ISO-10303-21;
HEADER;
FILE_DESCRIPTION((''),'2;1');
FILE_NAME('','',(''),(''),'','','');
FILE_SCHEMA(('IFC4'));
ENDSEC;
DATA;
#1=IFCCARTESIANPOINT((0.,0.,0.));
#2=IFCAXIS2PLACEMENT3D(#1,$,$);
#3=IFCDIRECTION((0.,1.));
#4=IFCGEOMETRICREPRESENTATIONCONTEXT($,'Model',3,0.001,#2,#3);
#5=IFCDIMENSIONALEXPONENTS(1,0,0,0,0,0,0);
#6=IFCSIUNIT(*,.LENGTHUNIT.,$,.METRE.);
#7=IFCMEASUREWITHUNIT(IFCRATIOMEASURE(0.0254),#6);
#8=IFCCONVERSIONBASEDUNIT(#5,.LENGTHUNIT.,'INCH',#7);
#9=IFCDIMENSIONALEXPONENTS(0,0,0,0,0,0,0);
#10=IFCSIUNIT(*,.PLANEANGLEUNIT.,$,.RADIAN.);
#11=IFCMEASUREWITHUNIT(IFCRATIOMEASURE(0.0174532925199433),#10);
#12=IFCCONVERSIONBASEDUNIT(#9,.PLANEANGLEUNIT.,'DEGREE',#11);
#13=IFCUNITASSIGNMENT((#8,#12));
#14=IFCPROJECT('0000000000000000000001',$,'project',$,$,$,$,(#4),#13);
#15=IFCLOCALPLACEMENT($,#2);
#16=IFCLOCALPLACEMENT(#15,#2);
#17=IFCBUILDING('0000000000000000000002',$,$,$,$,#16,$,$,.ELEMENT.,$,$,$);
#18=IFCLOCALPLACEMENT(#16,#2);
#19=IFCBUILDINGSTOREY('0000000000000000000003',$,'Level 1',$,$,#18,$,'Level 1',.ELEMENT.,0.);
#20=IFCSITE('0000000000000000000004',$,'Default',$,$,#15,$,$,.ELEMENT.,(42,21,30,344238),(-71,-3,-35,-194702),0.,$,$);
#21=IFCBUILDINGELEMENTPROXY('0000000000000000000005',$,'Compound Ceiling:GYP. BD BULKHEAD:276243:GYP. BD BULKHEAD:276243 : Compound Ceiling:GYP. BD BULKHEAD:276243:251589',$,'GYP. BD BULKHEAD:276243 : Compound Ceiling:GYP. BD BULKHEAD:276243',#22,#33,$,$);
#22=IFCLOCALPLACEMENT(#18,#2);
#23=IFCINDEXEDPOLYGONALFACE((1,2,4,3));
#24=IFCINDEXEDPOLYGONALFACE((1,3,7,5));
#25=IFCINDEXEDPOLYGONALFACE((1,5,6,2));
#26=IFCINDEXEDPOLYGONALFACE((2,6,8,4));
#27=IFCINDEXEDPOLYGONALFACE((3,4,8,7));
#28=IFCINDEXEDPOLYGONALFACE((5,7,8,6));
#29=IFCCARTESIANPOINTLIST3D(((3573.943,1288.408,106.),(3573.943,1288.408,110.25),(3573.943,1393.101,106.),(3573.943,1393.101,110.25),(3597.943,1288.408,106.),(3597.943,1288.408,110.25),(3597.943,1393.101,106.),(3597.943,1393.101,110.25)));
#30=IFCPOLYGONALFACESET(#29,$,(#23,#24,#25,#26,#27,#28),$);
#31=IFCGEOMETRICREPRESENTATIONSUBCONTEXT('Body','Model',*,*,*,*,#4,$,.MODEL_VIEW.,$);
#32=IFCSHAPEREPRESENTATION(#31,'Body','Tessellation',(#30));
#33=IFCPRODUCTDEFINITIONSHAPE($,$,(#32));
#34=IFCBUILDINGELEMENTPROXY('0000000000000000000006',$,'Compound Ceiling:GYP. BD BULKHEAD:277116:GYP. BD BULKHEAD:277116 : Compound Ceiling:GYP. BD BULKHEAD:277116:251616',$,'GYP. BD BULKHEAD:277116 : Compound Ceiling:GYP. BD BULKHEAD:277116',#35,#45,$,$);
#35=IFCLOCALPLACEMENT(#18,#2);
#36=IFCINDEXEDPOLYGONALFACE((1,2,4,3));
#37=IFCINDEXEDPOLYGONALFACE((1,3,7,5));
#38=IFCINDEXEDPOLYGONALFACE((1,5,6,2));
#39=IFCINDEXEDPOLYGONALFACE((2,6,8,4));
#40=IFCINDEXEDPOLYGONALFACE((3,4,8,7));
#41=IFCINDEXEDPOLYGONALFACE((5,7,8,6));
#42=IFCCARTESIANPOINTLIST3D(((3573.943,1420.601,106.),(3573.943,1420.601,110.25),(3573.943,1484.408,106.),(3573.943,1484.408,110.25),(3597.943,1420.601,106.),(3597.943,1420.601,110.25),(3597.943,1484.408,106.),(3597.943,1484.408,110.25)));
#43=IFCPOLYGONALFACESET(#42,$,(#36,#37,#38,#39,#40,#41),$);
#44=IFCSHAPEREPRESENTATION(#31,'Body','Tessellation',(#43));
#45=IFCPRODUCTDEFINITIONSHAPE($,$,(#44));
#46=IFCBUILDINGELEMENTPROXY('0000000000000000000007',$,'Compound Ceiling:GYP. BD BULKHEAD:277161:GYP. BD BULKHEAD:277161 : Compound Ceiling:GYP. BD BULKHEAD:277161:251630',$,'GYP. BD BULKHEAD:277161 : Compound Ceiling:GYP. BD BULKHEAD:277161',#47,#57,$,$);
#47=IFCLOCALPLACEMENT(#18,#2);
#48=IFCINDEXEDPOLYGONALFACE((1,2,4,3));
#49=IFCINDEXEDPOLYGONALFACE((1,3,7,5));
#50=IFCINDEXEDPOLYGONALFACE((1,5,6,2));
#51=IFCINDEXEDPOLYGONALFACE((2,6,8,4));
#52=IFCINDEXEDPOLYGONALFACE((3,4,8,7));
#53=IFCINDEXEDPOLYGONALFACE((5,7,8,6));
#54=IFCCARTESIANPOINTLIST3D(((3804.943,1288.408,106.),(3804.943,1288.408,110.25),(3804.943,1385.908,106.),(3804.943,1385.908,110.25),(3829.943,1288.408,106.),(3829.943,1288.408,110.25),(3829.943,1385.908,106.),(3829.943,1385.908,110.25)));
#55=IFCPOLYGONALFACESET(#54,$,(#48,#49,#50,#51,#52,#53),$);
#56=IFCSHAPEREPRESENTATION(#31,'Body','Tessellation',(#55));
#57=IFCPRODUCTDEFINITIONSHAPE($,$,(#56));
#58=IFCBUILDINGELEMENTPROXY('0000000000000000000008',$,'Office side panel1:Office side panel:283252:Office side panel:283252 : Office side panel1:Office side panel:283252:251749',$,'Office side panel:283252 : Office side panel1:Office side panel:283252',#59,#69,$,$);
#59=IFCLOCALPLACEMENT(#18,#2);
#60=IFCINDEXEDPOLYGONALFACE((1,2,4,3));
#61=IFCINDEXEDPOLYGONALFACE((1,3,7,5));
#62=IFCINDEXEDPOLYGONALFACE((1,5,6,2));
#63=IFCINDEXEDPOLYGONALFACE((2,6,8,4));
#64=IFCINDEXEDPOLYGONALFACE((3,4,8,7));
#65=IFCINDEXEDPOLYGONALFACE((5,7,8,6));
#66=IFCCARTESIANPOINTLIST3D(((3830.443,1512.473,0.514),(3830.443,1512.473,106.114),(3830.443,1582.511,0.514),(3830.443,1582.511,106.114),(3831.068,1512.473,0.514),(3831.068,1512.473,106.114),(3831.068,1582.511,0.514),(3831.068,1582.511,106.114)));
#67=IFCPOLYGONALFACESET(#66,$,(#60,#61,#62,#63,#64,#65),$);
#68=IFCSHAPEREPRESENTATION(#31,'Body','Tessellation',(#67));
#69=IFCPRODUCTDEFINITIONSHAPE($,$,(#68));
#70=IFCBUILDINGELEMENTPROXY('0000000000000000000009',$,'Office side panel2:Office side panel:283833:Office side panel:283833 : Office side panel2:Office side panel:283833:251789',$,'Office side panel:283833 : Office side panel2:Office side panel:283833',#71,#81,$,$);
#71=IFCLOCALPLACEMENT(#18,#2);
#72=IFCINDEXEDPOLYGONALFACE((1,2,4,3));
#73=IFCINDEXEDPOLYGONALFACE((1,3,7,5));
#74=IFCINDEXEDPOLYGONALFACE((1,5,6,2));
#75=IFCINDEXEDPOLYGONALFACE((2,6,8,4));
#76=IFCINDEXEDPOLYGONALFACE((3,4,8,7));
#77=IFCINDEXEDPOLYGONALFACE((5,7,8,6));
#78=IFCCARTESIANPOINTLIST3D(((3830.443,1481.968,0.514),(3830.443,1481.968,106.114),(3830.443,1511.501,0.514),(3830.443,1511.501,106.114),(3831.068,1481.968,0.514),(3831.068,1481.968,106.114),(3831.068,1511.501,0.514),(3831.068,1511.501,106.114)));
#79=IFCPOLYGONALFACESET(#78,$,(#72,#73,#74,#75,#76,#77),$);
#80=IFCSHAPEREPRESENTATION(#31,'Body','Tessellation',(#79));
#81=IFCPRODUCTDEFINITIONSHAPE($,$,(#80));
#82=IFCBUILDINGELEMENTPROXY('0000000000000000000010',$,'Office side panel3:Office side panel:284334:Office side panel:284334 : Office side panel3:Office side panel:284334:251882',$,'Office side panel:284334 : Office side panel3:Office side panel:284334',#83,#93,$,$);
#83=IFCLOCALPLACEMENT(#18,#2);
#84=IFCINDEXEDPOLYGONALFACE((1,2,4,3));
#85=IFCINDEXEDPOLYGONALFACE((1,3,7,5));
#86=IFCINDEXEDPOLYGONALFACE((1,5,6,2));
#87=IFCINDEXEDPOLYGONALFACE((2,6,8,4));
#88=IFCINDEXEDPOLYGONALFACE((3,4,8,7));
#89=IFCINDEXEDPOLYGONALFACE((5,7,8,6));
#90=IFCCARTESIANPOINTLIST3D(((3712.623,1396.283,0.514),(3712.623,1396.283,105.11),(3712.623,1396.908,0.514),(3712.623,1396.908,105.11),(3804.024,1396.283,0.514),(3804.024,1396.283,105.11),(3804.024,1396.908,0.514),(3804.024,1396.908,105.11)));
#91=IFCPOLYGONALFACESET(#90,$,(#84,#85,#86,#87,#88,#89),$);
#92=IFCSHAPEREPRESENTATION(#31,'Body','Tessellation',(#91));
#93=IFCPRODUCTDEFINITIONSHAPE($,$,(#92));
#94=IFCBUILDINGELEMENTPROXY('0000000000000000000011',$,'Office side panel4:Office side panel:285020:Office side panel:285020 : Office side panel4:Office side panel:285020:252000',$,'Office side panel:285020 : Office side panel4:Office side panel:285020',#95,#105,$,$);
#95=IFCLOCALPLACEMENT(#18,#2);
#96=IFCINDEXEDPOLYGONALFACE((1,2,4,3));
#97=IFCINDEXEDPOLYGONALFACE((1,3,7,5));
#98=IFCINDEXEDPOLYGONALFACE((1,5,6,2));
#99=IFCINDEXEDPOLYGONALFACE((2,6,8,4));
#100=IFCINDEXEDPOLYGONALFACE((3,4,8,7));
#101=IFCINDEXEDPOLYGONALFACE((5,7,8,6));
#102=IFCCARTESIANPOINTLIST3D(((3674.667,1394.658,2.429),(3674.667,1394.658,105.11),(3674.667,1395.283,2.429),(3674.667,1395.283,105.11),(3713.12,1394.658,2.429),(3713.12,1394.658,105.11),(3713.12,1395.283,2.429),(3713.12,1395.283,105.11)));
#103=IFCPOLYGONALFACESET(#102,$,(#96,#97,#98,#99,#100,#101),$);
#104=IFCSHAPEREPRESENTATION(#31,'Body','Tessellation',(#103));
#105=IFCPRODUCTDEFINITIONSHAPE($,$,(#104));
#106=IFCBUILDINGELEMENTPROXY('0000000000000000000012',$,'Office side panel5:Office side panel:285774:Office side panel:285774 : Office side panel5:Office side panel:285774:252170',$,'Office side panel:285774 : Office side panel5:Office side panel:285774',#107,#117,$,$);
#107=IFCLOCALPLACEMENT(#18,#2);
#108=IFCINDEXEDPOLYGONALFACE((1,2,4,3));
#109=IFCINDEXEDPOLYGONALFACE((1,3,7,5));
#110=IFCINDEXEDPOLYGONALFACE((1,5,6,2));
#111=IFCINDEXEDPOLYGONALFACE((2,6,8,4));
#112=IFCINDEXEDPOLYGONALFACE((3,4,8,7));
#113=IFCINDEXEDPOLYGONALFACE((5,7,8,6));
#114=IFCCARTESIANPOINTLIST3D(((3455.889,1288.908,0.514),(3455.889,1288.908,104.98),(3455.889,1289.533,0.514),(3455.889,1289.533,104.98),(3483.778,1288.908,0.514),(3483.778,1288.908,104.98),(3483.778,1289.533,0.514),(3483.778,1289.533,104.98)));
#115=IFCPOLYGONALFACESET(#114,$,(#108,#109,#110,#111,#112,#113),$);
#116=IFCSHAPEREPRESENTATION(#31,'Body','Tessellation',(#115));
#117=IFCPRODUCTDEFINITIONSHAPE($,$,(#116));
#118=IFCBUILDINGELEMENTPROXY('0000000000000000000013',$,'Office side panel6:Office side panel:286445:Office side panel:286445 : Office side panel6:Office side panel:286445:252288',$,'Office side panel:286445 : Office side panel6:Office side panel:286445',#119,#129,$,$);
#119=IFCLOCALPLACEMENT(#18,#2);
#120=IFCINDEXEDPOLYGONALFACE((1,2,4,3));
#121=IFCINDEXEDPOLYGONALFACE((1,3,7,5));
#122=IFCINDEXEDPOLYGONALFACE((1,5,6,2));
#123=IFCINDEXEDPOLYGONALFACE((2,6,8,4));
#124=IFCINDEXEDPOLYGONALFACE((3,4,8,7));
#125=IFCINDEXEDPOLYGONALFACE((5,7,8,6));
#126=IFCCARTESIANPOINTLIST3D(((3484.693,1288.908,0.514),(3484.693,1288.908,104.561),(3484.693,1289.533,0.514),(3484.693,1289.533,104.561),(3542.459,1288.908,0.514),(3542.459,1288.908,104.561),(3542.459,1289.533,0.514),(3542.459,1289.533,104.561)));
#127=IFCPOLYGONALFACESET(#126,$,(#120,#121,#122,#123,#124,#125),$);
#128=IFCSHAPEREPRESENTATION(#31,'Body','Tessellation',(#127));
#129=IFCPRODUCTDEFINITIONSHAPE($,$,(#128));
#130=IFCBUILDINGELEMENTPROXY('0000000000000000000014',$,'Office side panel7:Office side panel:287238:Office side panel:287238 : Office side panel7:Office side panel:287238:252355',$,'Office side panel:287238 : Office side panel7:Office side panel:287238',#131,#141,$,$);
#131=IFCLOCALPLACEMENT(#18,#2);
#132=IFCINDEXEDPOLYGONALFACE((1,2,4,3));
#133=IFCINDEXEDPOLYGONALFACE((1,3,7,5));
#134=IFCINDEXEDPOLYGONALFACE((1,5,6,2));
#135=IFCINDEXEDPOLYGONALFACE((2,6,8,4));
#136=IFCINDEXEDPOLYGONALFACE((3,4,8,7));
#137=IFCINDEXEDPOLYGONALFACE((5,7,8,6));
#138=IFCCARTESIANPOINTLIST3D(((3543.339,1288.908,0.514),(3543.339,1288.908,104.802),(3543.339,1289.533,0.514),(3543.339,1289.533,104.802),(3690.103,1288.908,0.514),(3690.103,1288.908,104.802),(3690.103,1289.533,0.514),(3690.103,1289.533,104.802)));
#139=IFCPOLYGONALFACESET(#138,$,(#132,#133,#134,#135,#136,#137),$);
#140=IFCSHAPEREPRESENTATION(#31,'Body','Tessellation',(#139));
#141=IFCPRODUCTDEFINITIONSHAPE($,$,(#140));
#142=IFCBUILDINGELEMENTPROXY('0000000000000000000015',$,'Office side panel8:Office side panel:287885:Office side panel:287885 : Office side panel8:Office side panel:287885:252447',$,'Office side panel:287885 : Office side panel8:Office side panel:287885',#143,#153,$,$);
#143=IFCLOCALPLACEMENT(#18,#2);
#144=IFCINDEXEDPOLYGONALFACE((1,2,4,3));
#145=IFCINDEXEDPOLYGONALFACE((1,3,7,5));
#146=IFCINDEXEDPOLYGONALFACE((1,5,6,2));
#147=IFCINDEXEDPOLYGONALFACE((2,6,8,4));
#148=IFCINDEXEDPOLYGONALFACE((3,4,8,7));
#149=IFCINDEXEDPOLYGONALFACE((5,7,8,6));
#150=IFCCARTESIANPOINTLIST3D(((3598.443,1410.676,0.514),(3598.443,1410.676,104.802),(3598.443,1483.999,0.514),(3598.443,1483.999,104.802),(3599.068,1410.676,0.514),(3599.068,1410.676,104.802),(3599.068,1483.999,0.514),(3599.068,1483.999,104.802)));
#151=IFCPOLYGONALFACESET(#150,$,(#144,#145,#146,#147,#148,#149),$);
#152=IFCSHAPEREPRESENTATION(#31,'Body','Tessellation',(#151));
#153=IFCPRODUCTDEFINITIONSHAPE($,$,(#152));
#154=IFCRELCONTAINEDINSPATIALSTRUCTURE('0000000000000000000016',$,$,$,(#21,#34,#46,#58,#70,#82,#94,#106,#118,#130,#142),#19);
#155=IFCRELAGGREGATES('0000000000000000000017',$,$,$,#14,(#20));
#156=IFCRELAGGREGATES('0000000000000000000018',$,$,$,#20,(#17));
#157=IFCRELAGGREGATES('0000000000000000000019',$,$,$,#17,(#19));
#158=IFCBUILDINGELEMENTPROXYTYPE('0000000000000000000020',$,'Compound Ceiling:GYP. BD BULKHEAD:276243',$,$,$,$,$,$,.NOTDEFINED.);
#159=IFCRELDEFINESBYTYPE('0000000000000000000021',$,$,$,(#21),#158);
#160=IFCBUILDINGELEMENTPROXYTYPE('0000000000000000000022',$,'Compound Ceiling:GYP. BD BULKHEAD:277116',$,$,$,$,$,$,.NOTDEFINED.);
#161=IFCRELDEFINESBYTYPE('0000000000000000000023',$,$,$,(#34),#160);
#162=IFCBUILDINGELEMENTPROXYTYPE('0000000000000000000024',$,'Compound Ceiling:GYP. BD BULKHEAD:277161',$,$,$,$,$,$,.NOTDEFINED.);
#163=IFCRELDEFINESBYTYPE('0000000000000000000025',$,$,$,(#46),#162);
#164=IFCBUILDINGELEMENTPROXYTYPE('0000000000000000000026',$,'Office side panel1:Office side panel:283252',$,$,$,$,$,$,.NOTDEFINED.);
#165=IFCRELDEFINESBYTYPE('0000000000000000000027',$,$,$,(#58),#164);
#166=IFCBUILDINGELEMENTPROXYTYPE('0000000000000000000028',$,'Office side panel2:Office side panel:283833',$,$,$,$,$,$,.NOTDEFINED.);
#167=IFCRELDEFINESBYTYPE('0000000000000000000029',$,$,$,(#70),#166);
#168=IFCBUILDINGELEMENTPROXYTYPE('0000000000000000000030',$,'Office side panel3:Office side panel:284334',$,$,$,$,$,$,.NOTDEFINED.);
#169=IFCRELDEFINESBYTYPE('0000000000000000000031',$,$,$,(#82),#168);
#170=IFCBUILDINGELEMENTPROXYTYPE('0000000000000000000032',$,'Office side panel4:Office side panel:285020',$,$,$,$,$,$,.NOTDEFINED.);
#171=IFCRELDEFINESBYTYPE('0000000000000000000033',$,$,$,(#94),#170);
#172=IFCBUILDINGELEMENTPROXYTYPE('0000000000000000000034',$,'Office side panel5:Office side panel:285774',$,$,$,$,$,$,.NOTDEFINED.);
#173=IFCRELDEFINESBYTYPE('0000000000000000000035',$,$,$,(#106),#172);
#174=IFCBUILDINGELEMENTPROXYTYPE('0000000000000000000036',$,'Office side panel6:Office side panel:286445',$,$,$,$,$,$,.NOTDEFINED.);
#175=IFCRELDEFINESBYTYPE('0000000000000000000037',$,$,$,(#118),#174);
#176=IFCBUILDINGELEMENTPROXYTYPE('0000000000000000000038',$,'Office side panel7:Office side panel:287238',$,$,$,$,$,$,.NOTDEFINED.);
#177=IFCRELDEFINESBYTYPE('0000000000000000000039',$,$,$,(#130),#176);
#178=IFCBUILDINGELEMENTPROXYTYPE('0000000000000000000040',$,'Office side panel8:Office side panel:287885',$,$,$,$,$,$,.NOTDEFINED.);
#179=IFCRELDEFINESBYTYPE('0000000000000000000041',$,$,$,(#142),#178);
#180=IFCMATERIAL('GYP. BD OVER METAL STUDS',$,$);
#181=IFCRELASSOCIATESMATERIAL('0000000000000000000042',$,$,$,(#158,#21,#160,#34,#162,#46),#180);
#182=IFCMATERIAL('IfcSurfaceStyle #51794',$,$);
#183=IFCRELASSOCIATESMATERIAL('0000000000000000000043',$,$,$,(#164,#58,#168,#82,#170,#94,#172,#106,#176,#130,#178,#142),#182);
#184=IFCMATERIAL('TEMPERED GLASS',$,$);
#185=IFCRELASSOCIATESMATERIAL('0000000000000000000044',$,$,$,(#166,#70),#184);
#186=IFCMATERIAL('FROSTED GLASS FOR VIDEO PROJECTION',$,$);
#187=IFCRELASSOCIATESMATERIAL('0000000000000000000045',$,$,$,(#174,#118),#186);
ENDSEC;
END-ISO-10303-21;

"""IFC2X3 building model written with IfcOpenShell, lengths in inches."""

from ifc_helpers import new_model, entity, si_unit, converted_unit, direction, frame, frame_2d, origin, origin_2d_with_axis, place, context, subcontext, project, spatial, rectangle, extrude, source, transform, mapped, material, type_object, type_shapes, element, save


model = new_model("IFC2X3")

# Units and contexts
model_context = context("Model", 3, precision=0.001, world=origin(), true_north=direction((0.0, 1.0)))
body_context = subcontext(model_context, "Body", "Model", "MODEL_VIEW")
ifc_project = project(units=[converted_unit("LENGTHUNIT", "INCH", entity("IfcRatioMeasure", 0.0254), si_unit("LENGTHUNIT", "METRE"), dimensions=[1, 0, 0, 0, 0, 0, 0]), converted_unit("PLANEANGLEUNIT", "DEGREE", entity("IfcRatioMeasure", 0.0174532925199433), si_unit("PLANEANGLEUNIT", "RADIAN"), dimensions=[0, 0, 0, 0, 0, 0, 0])], contexts=[model_context])

# Site, building, storey
site_placement = place(None, origin())
site = spatial("IfcSite", under=ifc_project, at=site_placement, Name="Default", CompositionType="ELEMENT", RefLatitude=(42, 21, 30, 344238), RefLongitude=(-71, -3, -35, -194702), RefElevation=0.0)
building_placement = place(site_placement, origin())
building = spatial("IfcBuilding", under=site, at=building_placement, CompositionType="ELEMENT")
storey_placement = place(building_placement, origin())
storey = spatial("IfcBuildingStorey", under=building, at=storey_placement, Name="Level 1", LongName="Level 1", CompositionType="ELEMENT", Elevation=0.0)

# Building element proxies
ifc_material_1 = material(Name="IfcSurfaceStyle #51794")
ifc_material_2 = material(Name="GYP. BD OVER METAL STUDS")
building_element_proxy_type_1 = type_object("IfcBuildingElementProxyType", Name="Compound Ceiling:GYP. BD BULKHEAD:276243", PredefinedType="NOTDEFINED", material=ifc_material_2)
shared_shape_1 = source(origin(), body_context, "Body", "SweptSolid", [
    extrude(rectangle(XDim=104.693, YDim=24.0, at=frame_2d((0.0, 0.0), x_axis=(1.0, 0.0))), frame((3585.943, 1340.754, 106.0), z_axis=(0.0, 0.0, 1.0), x_axis=(0.0, -1.0, 0.0)), (0.0, 0.0, 1.0), 4.25),
])
type_shapes(building_element_proxy_type_1, [shared_shape_1])
proxy_1_placement = place(storey_placement, origin())
element("IfcBuildingElementProxy", 1, at=proxy_1_placement, inside=storey, type_object=building_element_proxy_type_1, material=ifc_material_2, Name="Compound Ceiling:GYP. BD BULKHEAD:276243:GYP. BD BULKHEAD:276243 : Compound Ceiling:GYP. BD BULKHEAD:276243:251589", ObjectType="GYP. BD BULKHEAD:276243 : Compound Ceiling:GYP. BD BULKHEAD:276243", context=body_context, shape_type="MappedRepresentation", body=[
    mapped(shared_shape_1, transform((0.0, 0.0, 0.0), scale=1.0)),
])
building_element_proxy_type_2 = type_object("IfcBuildingElementProxyType", Name="Compound Ceiling:GYP. BD BULKHEAD:277116", PredefinedType="NOTDEFINED", material=ifc_material_2)
shared_shape_2 = source(origin(), body_context, "Body", "SweptSolid", [
    extrude(rectangle(XDim=63.807, YDim=24.0, at=origin_2d_with_axis()), frame((3585.943, 1452.504, 106.0), z_axis=(0.0, 0.0, 1.0), x_axis=(0.0, -1.0, 0.0)), (0.0, 0.0, 1.0), 4.25),
])
type_shapes(building_element_proxy_type_2, [shared_shape_2])
proxy_2_placement = place(storey_placement, origin())
element("IfcBuildingElementProxy", 2, at=proxy_2_placement, inside=storey, type_object=building_element_proxy_type_2, material=ifc_material_2, Name="Compound Ceiling:GYP. BD BULKHEAD:277116:GYP. BD BULKHEAD:277116 : Compound Ceiling:GYP. BD BULKHEAD:277116:251616", ObjectType="GYP. BD BULKHEAD:277116 : Compound Ceiling:GYP. BD BULKHEAD:277116", context=body_context, shape_type="MappedRepresentation", body=[
    mapped(shared_shape_2, transform((0.0, 0.0, 0.0), scale=1.0)),
])
building_element_proxy_type_3 = type_object("IfcBuildingElementProxyType", Name="Compound Ceiling:GYP. BD BULKHEAD:277161", PredefinedType="NOTDEFINED", material=ifc_material_2)
shared_shape_3 = source(origin(), body_context, "Body", "SweptSolid", [
    extrude(rectangle(XDim=97.5, YDim=25.0, at=frame_2d((0.0, 0.0), x_axis=(1.0, 0.0))), frame((3817.443, 1337.158, 106.0), z_axis=(0.0, 0.0, 1.0), x_axis=(0.0, -1.0, 0.0)), (0.0, 0.0, 1.0), 4.25),
])
type_shapes(building_element_proxy_type_3, [shared_shape_3])
proxy_3_placement = place(storey_placement, origin())
element("IfcBuildingElementProxy", 3, at=proxy_3_placement, inside=storey, type_object=building_element_proxy_type_3, material=ifc_material_2, Name="Compound Ceiling:GYP. BD BULKHEAD:277161:GYP. BD BULKHEAD:277161 : Compound Ceiling:GYP. BD BULKHEAD:277161:251630", ObjectType="GYP. BD BULKHEAD:277161 : Compound Ceiling:GYP. BD BULKHEAD:277161", context=body_context, shape_type="MappedRepresentation", body=[
    mapped(shared_shape_3, transform((0.0, 0.0, 0.0), scale=1.0)),
])
building_element_proxy_type_4 = type_object("IfcBuildingElementProxyType", Name="Office side panel1:Office side panel:283252", PredefinedType="NOTDEFINED", material=ifc_material_1)
shared_shape_4 = source(origin(), body_context, "Body", "SweptSolid", [
    extrude(rectangle(XDim=70.038, YDim=0.625, at=frame_2d((0.0, 0.0), x_axis=(1.0, 0.0))), frame((3830.756, 1547.492, 0.514), z_axis=(0.0, 0.0, 1.0), x_axis=(0.0, 1.0, 0.0)), (0.0, 0.0, 1.0), 105.6),
])
type_shapes(building_element_proxy_type_4, [shared_shape_4])
proxy_4_placement = place(storey_placement, origin())
element("IfcBuildingElementProxy", 4, at=proxy_4_placement, inside=storey, type_object=building_element_proxy_type_4, material=ifc_material_1, Name="Office side panel1:Office side panel:283252:Office side panel:283252 : Office side panel1:Office side panel:283252:251749", ObjectType="Office side panel:283252 : Office side panel1:Office side panel:283252", context=body_context, shape_type="MappedRepresentation", body=[
    mapped(shared_shape_4, transform((0.0, 0.0, 0.0), scale=1.0)),
])
ifc_material_3 = material(Name="TEMPERED GLASS")
building_element_proxy_type_5 = type_object("IfcBuildingElementProxyType", Name="Office side panel2:Office side panel:283833", PredefinedType="NOTDEFINED", material=ifc_material_3)
shared_shape_5 = source(origin(), body_context, "Body", "SweptSolid", [
    extrude(rectangle(XDim=29.532, YDim=0.625, at=frame_2d((0.0, 0.0), x_axis=(1.0, 0.0))), frame((3830.756, 1496.734, 0.514), z_axis=(0.0, 0.0, 1.0), x_axis=(0.0, 1.0, 0.0)), (0.0, 0.0, 1.0), 105.6),
])
type_shapes(building_element_proxy_type_5, [shared_shape_5])
proxy_5_placement = place(storey_placement, origin())
element("IfcBuildingElementProxy", 5, at=proxy_5_placement, inside=storey, type_object=building_element_proxy_type_5, material=ifc_material_3, Name="Office side panel2:Office side panel:283833:Office side panel:283833 : Office side panel2:Office side panel:283833:251789", ObjectType="Office side panel:283833 : Office side panel2:Office side panel:283833", context=body_context, shape_type="MappedRepresentation", body=[
    mapped(shared_shape_5, transform((0.0, 0.0, 0.0), scale=1.0)),
])
building_element_proxy_type_6 = type_object("IfcBuildingElementProxyType", Name="Office side panel3:Office side panel:284334", PredefinedType="NOTDEFINED", material=ifc_material_1)
shared_shape_6 = source(origin(), body_context, "Body", "SweptSolid", [
    extrude(rectangle(XDim=0.625, YDim=91.401, at=frame_2d((0.0, 0.0), x_axis=(1.0, 0.0))), frame((3758.324, 1396.595, 0.514), z_axis=(0.0, 0.0, 1.0), x_axis=(0.0, -1.0, 0.0)), (0.0, 0.0, 1.0), 104.597),
])
type_shapes(building_element_proxy_type_6, [shared_shape_6])
proxy_6_placement = place(storey_placement, origin())
element("IfcBuildingElementProxy", 6, at=proxy_6_placement, inside=storey, type_object=building_element_proxy_type_6, material=ifc_material_1, Name="Office side panel3:Office side panel:284334:Office side panel:284334 : Office side panel3:Office side panel:284334:251882", ObjectType="Office side panel:284334 : Office side panel3:Office side panel:284334", context=body_context, shape_type="MappedRepresentation", body=[
    mapped(shared_shape_6, transform((0.0, 0.0, 0.0), scale=1.0)),
])
building_element_proxy_type_7 = type_object("IfcBuildingElementProxyType", Name="Office side panel4:Office side panel:285020", PredefinedType="NOTDEFINED", material=ifc_material_1)
shared_shape_7 = source(origin(), body_context, "Body", "SweptSolid", [
    extrude(rectangle(XDim=0.625, YDim=38.453, at=frame_2d((0.0, 0.0), x_axis=(1.0, 0.0))), frame((3693.894, 1394.97, 2.429), z_axis=(0.0, 0.0, 1.0), x_axis=(0.0, -1.0, 0.0)), (0.0, 0.0, 1.0), 102.681),
])
type_shapes(building_element_proxy_type_7, [shared_shape_7])
proxy_7_placement = place(storey_placement, origin())
element("IfcBuildingElementProxy", 7, at=proxy_7_placement, inside=storey, type_object=building_element_proxy_type_7, material=ifc_material_1, Name="Office side panel4:Office side panel:285020:Office side panel:285020 : Office side panel4:Office side panel:285020:252000", ObjectType="Office side panel:285020 : Office side panel4:Office side panel:285020", context=body_context, shape_type="MappedRepresentation", body=[
    mapped(shared_shape_7, transform((0.0, 0.0, 0.0), scale=1.0)),
])
building_element_proxy_type_8 = type_object("IfcBuildingElementProxyType", Name="Office side panel5:Office side panel:285774", PredefinedType="NOTDEFINED", material=ifc_material_1)
shared_shape_8 = source(origin(), body_context, "Body", "SweptSolid", [
    extrude(rectangle(XDim=0.625, YDim=27.889, at=frame_2d((0.0, 0.0), x_axis=(1.0, 0.0))), frame((3469.834, 1289.22, 0.514), z_axis=(0.0, 0.0, 1.0), x_axis=(0.0, -1.0, 0.0)), (0.0, 0.0, 1.0), 104.466),
])
type_shapes(building_element_proxy_type_8, [shared_shape_8])
proxy_8_placement = place(storey_placement, origin())
element("IfcBuildingElementProxy", 8, at=proxy_8_placement, inside=storey, type_object=building_element_proxy_type_8, material=ifc_material_1, Name="Office side panel5:Office side panel:285774:Office side panel:285774 : Office side panel5:Office side panel:285774:252170", ObjectType="Office side panel:285774 : Office side panel5:Office side panel:285774", context=body_context, shape_type="MappedRepresentation", body=[
    mapped(shared_shape_8, transform((0.0, 0.0, 0.0), scale=1.0)),
])
ifc_material_4 = material(Name="FROSTED GLASS FOR VIDEO PROJECTION")
building_element_proxy_type_9 = type_object("IfcBuildingElementProxyType", Name="Office side panel6:Office side panel:286445", PredefinedType="NOTDEFINED", material=ifc_material_4)
shared_shape_9 = source(origin(), body_context, "Body", "SweptSolid", [
    extrude(rectangle(XDim=0.625, YDim=57.766, at=origin_2d_with_axis()), frame((3513.576, 1289.22, 0.514), z_axis=(0.0, 0.0, 1.0), x_axis=(0.0, -1.0, 0.0)), (0.0, 0.0, 1.0), 104.047),
])
type_shapes(building_element_proxy_type_9, [shared_shape_9])
proxy_9_placement = place(storey_placement, origin())
element("IfcBuildingElementProxy", 9, at=proxy_9_placement, inside=storey, type_object=building_element_proxy_type_9, material=ifc_material_4, Name="Office side panel6:Office side panel:286445:Office side panel:286445 : Office side panel6:Office side panel:286445:252288", ObjectType="Office side panel:286445 : Office side panel6:Office side panel:286445", context=body_context, shape_type="MappedRepresentation", body=[
    mapped(shared_shape_9, transform((0.0, 0.0, 0.0), scale=1.0)),
])
building_element_proxy_type_10 = type_object("IfcBuildingElementProxyType", Name="Office side panel7:Office side panel:287238", PredefinedType="NOTDEFINED", material=ifc_material_1)
shared_shape_10 = source(origin(), body_context, "Body", "SweptSolid", [
    extrude(rectangle(XDim=0.625, YDim=146.764, at=frame_2d((0.0, 0.0), x_axis=(1.0, 0.0))), frame((3616.721, 1289.22, 0.514), z_axis=(0.0, 0.0, 1.0), x_axis=(0.0, -1.0, 0.0)), (0.0, 0.0, 1.0), 104.288),
])
type_shapes(building_element_proxy_type_10, [shared_shape_10])
proxy_10_placement = place(storey_placement, origin())
element("IfcBuildingElementProxy", 10, at=proxy_10_placement, inside=storey, type_object=building_element_proxy_type_10, material=ifc_material_1, Name="Office side panel7:Office side panel:287238:Office side panel:287238 : Office side panel7:Office side panel:287238:252355", ObjectType="Office side panel:287238 : Office side panel7:Office side panel:287238", context=body_context, shape_type="MappedRepresentation", body=[
    mapped(shared_shape_10, transform((0.0, 0.0, 0.0), scale=1.0)),
])
building_element_proxy_type_11 = type_object("IfcBuildingElementProxyType", Name="Office side panel8:Office side panel:287885", PredefinedType="NOTDEFINED", material=ifc_material_1)
shared_shape_11 = source(origin(), body_context, "Body", "SweptSolid", [
    extrude(rectangle(XDim=73.323, YDim=0.625, at=frame_2d((0.0, 0.0), x_axis=(1.0, 0.0))), frame((3598.756, 1447.338, 0.514), z_axis=(0.0, 0.0, 1.0), x_axis=(0.0, 1.0, 0.0)), (0.0, 0.0, 1.0), 104.288),
])
type_shapes(building_element_proxy_type_11, [shared_shape_11])
proxy_11_placement = place(storey_placement, origin())
element("IfcBuildingElementProxy", 11, at=proxy_11_placement, inside=storey, type_object=building_element_proxy_type_11, material=ifc_material_1, Name="Office side panel8:Office side panel:287885:Office side panel:287885 : Office side panel8:Office side panel:287885:252447", ObjectType="Office side panel:287885 : Office side panel8:Office side panel:287885", context=body_context, shape_type="MappedRepresentation", body=[
    mapped(shared_shape_11, transform((0.0, 0.0, 0.0), scale=1.0)),
])

save(model, "model.ifc")
